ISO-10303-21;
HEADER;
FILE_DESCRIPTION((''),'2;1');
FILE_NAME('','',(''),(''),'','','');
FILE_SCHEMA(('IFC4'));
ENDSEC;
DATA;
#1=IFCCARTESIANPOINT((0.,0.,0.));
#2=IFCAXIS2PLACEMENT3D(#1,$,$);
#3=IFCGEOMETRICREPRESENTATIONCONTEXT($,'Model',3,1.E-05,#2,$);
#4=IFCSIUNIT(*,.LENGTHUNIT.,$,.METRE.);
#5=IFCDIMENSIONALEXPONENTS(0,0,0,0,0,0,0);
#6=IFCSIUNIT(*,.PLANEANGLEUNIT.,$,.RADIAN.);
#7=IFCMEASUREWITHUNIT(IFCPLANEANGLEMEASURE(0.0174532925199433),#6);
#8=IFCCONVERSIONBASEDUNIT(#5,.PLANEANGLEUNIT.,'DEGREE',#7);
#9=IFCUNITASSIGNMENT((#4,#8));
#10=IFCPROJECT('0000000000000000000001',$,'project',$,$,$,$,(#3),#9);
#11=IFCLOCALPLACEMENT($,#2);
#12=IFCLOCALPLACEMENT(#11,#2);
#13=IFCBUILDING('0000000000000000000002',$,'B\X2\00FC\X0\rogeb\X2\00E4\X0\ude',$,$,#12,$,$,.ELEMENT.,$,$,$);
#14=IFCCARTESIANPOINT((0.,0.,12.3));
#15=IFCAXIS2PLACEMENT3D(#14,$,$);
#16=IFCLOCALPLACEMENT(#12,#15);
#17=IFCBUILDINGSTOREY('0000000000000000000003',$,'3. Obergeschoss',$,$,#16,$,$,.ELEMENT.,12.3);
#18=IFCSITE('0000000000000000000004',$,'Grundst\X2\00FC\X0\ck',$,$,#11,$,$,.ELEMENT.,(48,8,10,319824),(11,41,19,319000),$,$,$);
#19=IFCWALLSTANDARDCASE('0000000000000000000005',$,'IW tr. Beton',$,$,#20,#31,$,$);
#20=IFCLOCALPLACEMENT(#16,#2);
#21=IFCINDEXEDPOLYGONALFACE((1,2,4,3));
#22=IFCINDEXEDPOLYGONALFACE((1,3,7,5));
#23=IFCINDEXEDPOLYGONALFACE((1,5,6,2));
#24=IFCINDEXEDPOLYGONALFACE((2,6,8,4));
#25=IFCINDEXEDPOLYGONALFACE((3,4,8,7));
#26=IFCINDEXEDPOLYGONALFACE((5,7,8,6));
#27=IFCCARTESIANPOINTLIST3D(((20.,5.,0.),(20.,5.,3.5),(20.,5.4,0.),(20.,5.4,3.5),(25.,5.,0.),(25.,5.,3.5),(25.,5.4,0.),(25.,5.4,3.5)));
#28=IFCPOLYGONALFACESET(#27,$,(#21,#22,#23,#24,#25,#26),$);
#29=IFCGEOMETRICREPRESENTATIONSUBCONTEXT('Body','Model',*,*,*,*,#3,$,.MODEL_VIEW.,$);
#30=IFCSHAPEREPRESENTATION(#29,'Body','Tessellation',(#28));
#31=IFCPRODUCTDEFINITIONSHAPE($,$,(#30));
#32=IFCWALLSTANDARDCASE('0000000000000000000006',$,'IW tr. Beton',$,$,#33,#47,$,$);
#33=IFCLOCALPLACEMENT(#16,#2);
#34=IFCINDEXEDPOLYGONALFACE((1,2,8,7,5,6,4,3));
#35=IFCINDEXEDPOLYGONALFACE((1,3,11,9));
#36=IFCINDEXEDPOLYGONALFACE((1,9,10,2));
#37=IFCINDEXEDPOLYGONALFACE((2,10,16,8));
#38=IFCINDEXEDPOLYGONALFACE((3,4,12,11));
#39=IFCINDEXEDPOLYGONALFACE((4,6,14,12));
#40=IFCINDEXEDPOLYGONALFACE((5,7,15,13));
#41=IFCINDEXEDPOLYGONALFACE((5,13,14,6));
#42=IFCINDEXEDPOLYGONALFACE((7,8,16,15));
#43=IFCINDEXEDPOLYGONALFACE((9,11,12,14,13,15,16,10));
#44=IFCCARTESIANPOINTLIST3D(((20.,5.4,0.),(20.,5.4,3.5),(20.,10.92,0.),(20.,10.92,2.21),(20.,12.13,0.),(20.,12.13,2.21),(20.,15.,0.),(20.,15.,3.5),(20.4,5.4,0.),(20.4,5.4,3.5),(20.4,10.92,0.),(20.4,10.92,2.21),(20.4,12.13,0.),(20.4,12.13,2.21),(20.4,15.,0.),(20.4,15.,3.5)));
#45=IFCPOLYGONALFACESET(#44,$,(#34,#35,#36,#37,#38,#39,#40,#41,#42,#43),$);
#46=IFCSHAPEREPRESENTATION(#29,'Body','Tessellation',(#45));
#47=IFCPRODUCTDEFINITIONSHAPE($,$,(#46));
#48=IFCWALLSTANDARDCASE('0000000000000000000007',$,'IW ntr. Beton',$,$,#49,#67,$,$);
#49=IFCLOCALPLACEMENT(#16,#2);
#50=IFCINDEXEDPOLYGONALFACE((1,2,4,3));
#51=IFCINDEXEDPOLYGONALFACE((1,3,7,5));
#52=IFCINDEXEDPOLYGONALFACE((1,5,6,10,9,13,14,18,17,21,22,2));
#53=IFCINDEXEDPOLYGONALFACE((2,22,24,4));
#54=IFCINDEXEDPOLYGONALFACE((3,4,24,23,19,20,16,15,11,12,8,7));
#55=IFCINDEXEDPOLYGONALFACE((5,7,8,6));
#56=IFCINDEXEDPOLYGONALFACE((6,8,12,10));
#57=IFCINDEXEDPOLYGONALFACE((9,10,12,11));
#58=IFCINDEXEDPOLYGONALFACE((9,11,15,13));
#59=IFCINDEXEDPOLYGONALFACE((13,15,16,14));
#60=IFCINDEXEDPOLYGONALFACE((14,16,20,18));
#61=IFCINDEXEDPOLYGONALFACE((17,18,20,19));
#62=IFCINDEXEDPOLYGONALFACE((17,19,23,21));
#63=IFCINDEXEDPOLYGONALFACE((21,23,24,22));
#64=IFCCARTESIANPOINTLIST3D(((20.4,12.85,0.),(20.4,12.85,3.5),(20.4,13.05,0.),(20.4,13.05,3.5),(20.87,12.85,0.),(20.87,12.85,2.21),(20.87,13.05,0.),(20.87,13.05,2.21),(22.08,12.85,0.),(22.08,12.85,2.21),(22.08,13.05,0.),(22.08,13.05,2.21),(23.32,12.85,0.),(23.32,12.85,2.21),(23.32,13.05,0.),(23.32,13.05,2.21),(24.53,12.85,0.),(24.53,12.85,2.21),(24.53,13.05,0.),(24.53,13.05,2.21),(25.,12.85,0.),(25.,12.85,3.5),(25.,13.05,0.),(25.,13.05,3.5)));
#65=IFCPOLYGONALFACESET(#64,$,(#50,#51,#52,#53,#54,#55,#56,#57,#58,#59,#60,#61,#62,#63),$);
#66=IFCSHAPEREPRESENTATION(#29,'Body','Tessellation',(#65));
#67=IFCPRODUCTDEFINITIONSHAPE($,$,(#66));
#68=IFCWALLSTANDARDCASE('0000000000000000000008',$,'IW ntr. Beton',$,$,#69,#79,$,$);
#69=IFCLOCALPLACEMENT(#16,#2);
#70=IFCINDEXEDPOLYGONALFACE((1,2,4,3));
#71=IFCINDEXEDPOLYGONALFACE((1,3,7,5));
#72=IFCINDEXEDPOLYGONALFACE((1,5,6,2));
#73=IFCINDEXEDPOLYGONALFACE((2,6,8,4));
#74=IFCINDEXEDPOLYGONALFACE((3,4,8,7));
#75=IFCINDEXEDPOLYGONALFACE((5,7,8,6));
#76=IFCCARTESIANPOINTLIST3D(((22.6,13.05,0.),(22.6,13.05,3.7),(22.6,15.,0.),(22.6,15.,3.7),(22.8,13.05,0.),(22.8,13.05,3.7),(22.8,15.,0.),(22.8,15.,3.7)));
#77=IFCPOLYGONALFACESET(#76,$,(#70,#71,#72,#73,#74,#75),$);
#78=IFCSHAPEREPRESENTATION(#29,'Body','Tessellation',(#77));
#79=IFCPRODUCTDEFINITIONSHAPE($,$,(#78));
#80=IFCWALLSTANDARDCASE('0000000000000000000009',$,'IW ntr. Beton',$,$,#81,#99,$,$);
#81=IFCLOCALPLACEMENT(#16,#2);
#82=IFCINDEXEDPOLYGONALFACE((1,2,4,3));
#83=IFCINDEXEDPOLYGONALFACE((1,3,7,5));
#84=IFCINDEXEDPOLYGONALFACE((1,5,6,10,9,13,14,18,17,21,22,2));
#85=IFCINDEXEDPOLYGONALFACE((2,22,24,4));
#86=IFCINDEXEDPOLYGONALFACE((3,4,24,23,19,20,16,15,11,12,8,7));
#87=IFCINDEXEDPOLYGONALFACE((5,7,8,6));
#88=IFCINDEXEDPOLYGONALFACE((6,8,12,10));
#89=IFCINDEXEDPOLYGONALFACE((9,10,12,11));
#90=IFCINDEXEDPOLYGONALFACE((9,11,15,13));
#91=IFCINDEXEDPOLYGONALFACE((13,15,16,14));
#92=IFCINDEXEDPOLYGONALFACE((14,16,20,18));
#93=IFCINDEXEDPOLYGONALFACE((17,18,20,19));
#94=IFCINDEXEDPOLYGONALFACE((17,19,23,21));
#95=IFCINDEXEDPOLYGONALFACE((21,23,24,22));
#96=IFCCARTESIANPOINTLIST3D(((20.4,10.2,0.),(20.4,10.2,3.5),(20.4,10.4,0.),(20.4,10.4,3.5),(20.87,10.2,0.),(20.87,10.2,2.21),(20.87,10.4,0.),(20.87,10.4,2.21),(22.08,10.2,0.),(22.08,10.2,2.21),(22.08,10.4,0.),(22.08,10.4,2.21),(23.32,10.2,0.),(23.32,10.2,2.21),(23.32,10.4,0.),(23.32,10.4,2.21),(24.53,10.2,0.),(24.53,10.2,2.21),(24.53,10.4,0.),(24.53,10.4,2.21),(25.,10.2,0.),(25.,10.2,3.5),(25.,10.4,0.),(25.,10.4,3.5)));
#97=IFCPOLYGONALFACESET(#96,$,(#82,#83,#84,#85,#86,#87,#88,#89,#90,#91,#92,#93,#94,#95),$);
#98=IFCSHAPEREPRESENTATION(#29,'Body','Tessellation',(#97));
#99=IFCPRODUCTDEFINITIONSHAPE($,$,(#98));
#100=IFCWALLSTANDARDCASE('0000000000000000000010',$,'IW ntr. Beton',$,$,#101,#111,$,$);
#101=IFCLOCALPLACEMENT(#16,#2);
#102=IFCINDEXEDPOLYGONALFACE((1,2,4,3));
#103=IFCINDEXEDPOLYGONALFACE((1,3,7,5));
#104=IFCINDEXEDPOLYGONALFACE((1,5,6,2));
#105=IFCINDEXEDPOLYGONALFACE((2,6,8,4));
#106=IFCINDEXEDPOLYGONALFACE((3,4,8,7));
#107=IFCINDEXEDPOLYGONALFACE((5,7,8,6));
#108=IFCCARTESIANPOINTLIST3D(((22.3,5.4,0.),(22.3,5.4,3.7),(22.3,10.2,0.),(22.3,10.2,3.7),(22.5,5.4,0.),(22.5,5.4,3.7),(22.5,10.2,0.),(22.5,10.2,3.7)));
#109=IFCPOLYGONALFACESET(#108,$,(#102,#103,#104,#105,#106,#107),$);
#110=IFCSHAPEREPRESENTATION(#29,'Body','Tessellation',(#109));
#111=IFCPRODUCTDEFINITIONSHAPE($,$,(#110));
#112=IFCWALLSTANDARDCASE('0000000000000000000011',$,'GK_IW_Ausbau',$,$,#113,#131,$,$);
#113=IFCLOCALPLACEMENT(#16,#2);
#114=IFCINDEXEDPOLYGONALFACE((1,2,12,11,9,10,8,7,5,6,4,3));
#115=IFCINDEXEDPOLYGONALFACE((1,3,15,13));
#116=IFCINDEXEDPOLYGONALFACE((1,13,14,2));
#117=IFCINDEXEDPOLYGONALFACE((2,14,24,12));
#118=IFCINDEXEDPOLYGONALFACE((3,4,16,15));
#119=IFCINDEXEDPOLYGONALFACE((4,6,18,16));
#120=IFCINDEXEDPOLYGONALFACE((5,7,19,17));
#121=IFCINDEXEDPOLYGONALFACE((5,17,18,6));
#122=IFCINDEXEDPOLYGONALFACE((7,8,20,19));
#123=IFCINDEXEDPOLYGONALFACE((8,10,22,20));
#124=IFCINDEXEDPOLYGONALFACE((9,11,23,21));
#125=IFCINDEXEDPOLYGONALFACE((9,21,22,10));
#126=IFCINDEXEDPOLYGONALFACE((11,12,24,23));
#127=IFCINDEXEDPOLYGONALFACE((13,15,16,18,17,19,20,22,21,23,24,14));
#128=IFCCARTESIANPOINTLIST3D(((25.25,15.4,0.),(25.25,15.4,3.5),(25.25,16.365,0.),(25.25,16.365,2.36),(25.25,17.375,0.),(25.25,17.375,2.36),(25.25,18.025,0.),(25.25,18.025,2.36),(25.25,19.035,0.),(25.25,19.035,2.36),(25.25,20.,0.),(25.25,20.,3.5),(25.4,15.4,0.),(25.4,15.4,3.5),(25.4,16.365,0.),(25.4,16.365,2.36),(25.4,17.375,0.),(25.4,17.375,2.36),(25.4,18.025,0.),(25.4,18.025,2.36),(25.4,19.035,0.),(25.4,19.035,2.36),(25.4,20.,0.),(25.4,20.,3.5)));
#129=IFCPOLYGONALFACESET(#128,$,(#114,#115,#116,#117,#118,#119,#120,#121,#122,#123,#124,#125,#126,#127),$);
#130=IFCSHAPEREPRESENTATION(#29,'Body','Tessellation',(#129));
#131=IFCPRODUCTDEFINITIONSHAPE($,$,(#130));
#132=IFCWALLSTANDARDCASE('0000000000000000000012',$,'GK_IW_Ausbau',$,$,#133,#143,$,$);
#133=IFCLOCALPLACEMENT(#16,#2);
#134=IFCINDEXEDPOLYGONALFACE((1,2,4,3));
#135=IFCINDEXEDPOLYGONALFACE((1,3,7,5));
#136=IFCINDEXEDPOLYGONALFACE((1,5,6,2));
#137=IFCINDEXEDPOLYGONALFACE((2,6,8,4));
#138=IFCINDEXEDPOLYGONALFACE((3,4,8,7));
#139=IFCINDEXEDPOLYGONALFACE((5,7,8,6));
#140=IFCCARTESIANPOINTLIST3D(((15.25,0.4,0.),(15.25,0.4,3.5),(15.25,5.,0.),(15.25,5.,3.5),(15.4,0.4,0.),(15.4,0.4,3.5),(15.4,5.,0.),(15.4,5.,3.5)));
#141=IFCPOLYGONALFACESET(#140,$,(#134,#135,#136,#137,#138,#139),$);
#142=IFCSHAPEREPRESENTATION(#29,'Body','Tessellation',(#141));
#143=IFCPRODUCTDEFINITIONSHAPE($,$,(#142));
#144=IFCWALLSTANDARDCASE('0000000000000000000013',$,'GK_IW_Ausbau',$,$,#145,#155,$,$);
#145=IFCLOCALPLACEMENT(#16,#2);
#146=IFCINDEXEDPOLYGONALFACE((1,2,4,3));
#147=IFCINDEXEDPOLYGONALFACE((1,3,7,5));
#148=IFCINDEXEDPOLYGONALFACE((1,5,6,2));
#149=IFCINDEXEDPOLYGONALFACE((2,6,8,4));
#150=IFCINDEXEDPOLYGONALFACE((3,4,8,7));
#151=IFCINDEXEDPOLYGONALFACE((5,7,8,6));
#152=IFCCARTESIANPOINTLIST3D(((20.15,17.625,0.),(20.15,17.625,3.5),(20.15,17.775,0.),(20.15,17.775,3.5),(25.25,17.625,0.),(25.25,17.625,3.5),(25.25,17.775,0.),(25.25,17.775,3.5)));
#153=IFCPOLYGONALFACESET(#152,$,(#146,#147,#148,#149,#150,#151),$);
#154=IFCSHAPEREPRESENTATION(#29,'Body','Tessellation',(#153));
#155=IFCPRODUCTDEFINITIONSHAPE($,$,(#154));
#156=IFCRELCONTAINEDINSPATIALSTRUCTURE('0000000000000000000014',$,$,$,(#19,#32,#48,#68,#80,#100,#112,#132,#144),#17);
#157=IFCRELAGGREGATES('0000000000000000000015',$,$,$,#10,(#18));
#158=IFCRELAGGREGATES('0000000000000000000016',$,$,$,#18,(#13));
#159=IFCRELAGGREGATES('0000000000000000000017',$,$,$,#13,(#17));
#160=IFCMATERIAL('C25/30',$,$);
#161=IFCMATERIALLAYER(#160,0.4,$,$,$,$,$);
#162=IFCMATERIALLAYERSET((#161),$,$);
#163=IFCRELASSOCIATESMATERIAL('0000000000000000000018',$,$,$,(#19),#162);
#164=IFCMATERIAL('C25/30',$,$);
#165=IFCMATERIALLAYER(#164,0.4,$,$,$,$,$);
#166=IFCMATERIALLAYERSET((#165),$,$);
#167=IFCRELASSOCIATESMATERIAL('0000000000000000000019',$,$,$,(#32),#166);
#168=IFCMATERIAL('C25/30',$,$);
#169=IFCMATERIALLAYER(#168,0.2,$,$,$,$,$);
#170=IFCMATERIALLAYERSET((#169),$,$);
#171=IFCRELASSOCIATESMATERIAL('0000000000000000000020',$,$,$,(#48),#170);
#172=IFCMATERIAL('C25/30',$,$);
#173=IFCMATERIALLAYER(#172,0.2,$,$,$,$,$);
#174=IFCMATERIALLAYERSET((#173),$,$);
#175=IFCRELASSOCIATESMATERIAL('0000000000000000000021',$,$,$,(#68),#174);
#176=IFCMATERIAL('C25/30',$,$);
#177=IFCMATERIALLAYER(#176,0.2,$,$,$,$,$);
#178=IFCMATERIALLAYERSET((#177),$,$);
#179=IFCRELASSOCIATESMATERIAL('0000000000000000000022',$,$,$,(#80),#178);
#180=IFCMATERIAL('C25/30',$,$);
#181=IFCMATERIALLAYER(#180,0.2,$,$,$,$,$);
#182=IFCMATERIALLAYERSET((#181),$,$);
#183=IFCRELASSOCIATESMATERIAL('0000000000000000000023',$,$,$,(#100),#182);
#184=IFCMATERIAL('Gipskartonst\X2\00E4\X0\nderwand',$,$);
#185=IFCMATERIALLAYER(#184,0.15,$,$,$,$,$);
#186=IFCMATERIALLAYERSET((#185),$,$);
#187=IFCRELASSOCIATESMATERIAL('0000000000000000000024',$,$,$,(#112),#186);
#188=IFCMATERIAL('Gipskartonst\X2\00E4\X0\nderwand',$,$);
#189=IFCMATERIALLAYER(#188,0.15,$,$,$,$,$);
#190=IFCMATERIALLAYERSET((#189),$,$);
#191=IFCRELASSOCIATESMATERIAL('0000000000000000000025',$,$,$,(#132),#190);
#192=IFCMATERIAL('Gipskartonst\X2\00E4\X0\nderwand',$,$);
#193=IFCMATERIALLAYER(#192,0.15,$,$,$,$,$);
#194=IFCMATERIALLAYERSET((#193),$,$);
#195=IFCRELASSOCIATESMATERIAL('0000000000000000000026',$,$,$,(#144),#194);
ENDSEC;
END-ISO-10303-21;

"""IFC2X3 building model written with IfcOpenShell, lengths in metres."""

from ifc_helpers import new_model, entity, si_unit, converted_unit, frame, frame_2d, origin, origin_with_axes, place, context, subcontext, project, spatial, polyline, rectangle, outline, extrude, material, layer, layer_set, layer_usage, element, save


model = new_model("IFC2X3")

# Units and contexts
model_context = context("Model", 3, precision=1e-05, world=origin())
body_context = subcontext(model_context, "Body", "Model", "MODEL_VIEW")
ifc_project = project(units=[si_unit("LENGTHUNIT", "METRE"), converted_unit("PLANEANGLEUNIT", "DEGREE", entity("IfcPlaneAngleMeasure", 0.0174532925199433), si_unit("PLANEANGLEUNIT", "RADIAN"), dimensions=[0, 0, 0, 0, 0, 0, 0])], contexts=[model_context])

# Site, building, storey
site_placement = place(None, origin())
site = spatial("IfcSite", under=ifc_project, at=site_placement, Name="Grundstück", CompositionType="ELEMENT", RefLatitude=(48, 8, 10, 319824), RefLongitude=(11, 41, 19, 319000))
building_placement = place(site_placement, origin())
building = spatial("IfcBuilding", under=site, at=building_placement, Name="Bürogebäude", CompositionType="ELEMENT")
storey_placement = place(building_placement, frame((0.0, 0.0, 12.3)))
storey = spatial("IfcBuildingStorey", under=building, at=storey_placement, Name="3. Obergeschoss", CompositionType="ELEMENT", Elevation=12.3)

# Wall
ifc_material_1 = material(Name="C25/30")
ifc_layer_1 = layer(ifc_material_1, 0.4)
ifc_layer_set_1 = layer_set([ifc_layer_1])
ifc_layer_usage_1 = layer_usage(ifc_layer_set_1, "AXIS2", "POSITIVE", -0.2)
wall_1_placement = place(storey_placement, frame((25.0, 5.4, 0.0), z_axis=(0.0, 0.0, 1.0), x_axis=(-1.0, 0.0, 0.0)))
element("IfcWallStandardCase", 1, at=wall_1_placement, inside=storey, material=ifc_layer_usage_1, Name="IW tr. Beton", context=body_context, shape_type="SweptSolid", body=[
    extrude(rectangle(XDim=5.0, YDim=0.4, at=frame_2d((2.5, 0.2), x_axis=(1.0, 0.0))), origin_with_axes(), (0.0, 0.0, 1.0), 3.5),
])

# Wall, opening
ifc_material_2 = material(Name="C25/30")
ifc_layer_2 = layer(ifc_material_2, 0.4)
ifc_layer_set_2 = layer_set([ifc_layer_2])
ifc_layer_usage_2 = layer_usage(ifc_layer_set_2, "AXIS2", "POSITIVE", -0.2)
wall_2_placement = place(storey_placement, frame((20.4, 5.4, 0.0), z_axis=(0.0, 0.0, 1.0), x_axis=(0.0, 1.0, 0.0)))
wall_2 = element("IfcWallStandardCase", 2, at=wall_2_placement, inside=storey, material=ifc_layer_usage_2, Name="IW tr. Beton", context=body_context, shape_type="SweptSolid", body=[
    extrude(rectangle(XDim=9.6, YDim=0.4, at=frame_2d((4.8, 0.2), x_axis=(1.0, 0.0))), origin_with_axes(), (0.0, 0.0, 1.0), 3.5),
])
opening_1_placement = place(wall_2_placement, frame((5.52, 0.0, 0.0), z_axis=(0.0, 1.0, 0.0), x_axis=(0.0, 0.0, 1.0)))
element("IfcOpeningElement", 3, at=opening_1_placement, cuts=wall_2, ObjectType="Opening", context=body_context, shape_type="SweptSolid", body=[
    extrude(outline(polyline([(0.0, 1.21), (2.21, 1.21), (2.21, 0.0), (0.0, 0.0), (0.0, 1.21)])), origin_with_axes(), (0.0, 0.0, 1.0), 0.4),
])

# Wall, openings
ifc_material_3 = material(Name="C25/30")
ifc_layer_3 = layer(ifc_material_3, 0.2)
ifc_layer_set_3 = layer_set([ifc_layer_3])
ifc_layer_usage_3 = layer_usage(ifc_layer_set_3, "AXIS2", "POSITIVE", -0.2)
wall_3_placement = place(storey_placement, frame((25.0, 13.05, 0.0), z_axis=(0.0, 0.0, 1.0), x_axis=(-1.0, 0.0, 0.0)))
wall_3 = element("IfcWallStandardCase", 4, at=wall_3_placement, inside=storey, material=ifc_layer_usage_3, Name="IW ntr. Beton", context=body_context, shape_type="SweptSolid", body=[
    extrude(rectangle(XDim=4.6, YDim=0.2, at=frame_2d((2.3, 0.1), x_axis=(1.0, 0.0))), origin_with_axes(), (0.0, 0.0, 1.0), 3.5),
])
opening_2_placement = place(wall_3_placement, frame((1.68, 0.2, 0.0), z_axis=(0.0, -1.0, 0.0), x_axis=(0.0, 0.0, 1.0)))
element("IfcOpeningElement", 5, at=opening_2_placement, cuts=wall_3, ObjectType="Opening", context=body_context, shape_type="SweptSolid", body=[
    extrude(outline(polyline([(0.0, 1.21), (2.21, 1.21), (2.21, 0.0), (0.0, 0.0), (0.0, 1.21)])), origin_with_axes(), (0.0, 0.0, 1.0), 0.2),
])
opening_3_placement = place(wall_3_placement, frame((4.13, 0.2, 0.0), z_axis=(0.0, -1.0, 0.0), x_axis=(0.0, 0.0, 1.0)))
element("IfcOpeningElement", 6, at=opening_3_placement, cuts=wall_3, ObjectType="Opening", context=body_context, shape_type="SweptSolid", body=[
    extrude(outline(polyline([(0.0, 1.21), (2.21, 1.21), (2.21, 0.0), (0.0, 0.0), (0.0, 1.21)])), origin_with_axes(), (0.0, 0.0, 1.0), 0.2),
])

# Wall
ifc_material_4 = material(Name="C25/30")
ifc_layer_4 = layer(ifc_material_4, 0.2)
ifc_layer_set_4 = layer_set([ifc_layer_4])
ifc_layer_usage_4 = layer_usage(ifc_layer_set_4, "AXIS2", "POSITIVE", -0.2)
wall_4_placement = place(storey_placement, frame((22.6, 15.0, 0.0), z_axis=(0.0, 0.0, 1.0), x_axis=(0.0, -1.0, 0.0)))
element("IfcWallStandardCase", 7, at=wall_4_placement, inside=storey, material=ifc_layer_usage_4, Name="IW ntr. Beton", context=body_context, shape_type="SweptSolid", body=[
    extrude(rectangle(XDim=1.95, YDim=0.2, at=frame_2d((0.975, 0.1), x_axis=(1.0, 0.0))), origin_with_axes(), (0.0, 0.0, 1.0), 3.7),
])

# Wall, openings
ifc_material_5 = material(Name="C25/30")
ifc_layer_5 = layer(ifc_material_5, 0.2)
ifc_layer_set_5 = layer_set([ifc_layer_5])
ifc_layer_usage_5 = layer_usage(ifc_layer_set_5, "AXIS2", "POSITIVE", -0.2)
wall_5_placement = place(storey_placement, frame((25.0, 10.4, 0.0), z_axis=(0.0, 0.0, 1.0), x_axis=(-1.0, 0.0, 0.0)))
wall_5 = element("IfcWallStandardCase", 8, at=wall_5_placement, inside=storey, material=ifc_layer_usage_5, Name="IW ntr. Beton", context=body_context, shape_type="SweptSolid", body=[
    extrude(rectangle(XDim=4.6, YDim=0.2, at=frame_2d((2.3, 0.1), x_axis=(1.0, 0.0))), origin_with_axes(), (0.0, 0.0, 1.0), 3.5),
])
opening_4_placement = place(wall_5_placement, frame((1.68, 0.2, 0.0), z_axis=(0.0, -1.0, 0.0), x_axis=(0.0, 0.0, 1.0)))
element("IfcOpeningElement", 9, at=opening_4_placement, cuts=wall_5, ObjectType="Opening", context=body_context, shape_type="SweptSolid", body=[
    extrude(outline(polyline([(0.0, 1.21), (2.21, 1.21), (2.21, 0.0), (0.0, 0.0), (0.0, 1.21)])), origin_with_axes(), (0.0, 0.0, 1.0), 0.2),
])
opening_5_placement = place(wall_5_placement, frame((4.13, 0.2, 0.0), z_axis=(0.0, -1.0, 0.0), x_axis=(0.0, 0.0, 1.0)))
element("IfcOpeningElement", 10, at=opening_5_placement, cuts=wall_5, ObjectType="Opening", context=body_context, shape_type="SweptSolid", body=[
    extrude(outline(polyline([(0.0, 1.21), (2.21, 1.21), (2.21, 0.0), (0.0, 0.0), (0.0, 1.21)])), origin_with_axes(), (0.0, 0.0, 1.0), 0.2),
])

# Wall
ifc_material_6 = material(Name="C25/30")
ifc_layer_6 = layer(ifc_material_6, 0.2)
ifc_layer_set_6 = layer_set([ifc_layer_6])
ifc_layer_usage_6 = layer_usage(ifc_layer_set_6, "AXIS2", "POSITIVE", -0.2)
wall_6_placement = place(storey_placement, frame((22.3, 10.2, 0.0), z_axis=(0.0, 0.0, 1.0), x_axis=(0.0, -1.0, 0.0)))
element("IfcWallStandardCase", 11, at=wall_6_placement, inside=storey, material=ifc_layer_usage_6, Name="IW ntr. Beton", context=body_context, shape_type="SweptSolid", body=[
    extrude(rectangle(XDim=4.8, YDim=0.2, at=frame_2d((2.4, 0.1), x_axis=(1.0, 0.0))), origin_with_axes(), (0.0, 0.0, 1.0), 3.7),
])

# Wall, openings
ifc_material_7 = material(Name="Gipskartonständerwand")
ifc_layer_7 = layer(ifc_material_7, 0.15)
ifc_layer_set_7 = layer_set([ifc_layer_7])
ifc_layer_usage_7 = layer_usage(ifc_layer_set_7, "AXIS2", "POSITIVE", -0.15)
wall_7_placement = place(storey_placement, frame((25.25, 20.0, 0.0), z_axis=(0.0, 0.0, 1.0), x_axis=(0.0, -1.0, 0.0)))
wall_7 = element("IfcWallStandardCase", 12, at=wall_7_placement, inside=storey, material=ifc_layer_usage_7, Name="GK_IW_Ausbau", context=body_context, shape_type="SweptSolid", body=[
    extrude(rectangle(XDim=4.6, YDim=0.15, at=frame_2d((2.3, 0.075), x_axis=(1.0, 0.0))), origin_with_axes(), (0.0, 0.0, 1.0), 3.5),
])
opening_6_placement = place(wall_7_placement, frame((1.975, 0.15, 0.0), z_axis=(0.0, -1.0, 0.0), x_axis=(0.0, 0.0, 1.0)))
element("IfcOpeningElement", 13, at=opening_6_placement, cuts=wall_7, ObjectType="Opening", context=body_context, shape_type="SweptSolid", body=[
    extrude(outline(polyline([(0.0, 1.01), (2.36, 1.01), (2.36, 0.0), (0.0, 0.0), (0.0, 1.01)])), origin_with_axes(), (0.0, 0.0, 1.0), 0.15),
])
opening_7_placement = place(wall_7_placement, frame((3.635, 0.15, 0.0), z_axis=(0.0, -1.0, 0.0), x_axis=(0.0, 0.0, 1.0)))
element("IfcOpeningElement", 14, at=opening_7_placement, cuts=wall_7, ObjectType="Opening", context=body_context, shape_type="SweptSolid", body=[
    extrude(outline(polyline([(0.0, 1.01), (2.36, 1.01), (2.36, 0.0), (0.0, 0.0), (0.0, 1.01)])), origin_with_axes(), (0.0, 0.0, 1.0), 0.15),
])

# Walls
ifc_material_8 = material(Name="Gipskartonständerwand")
ifc_layer_8 = layer(ifc_material_8, 0.15)
ifc_layer_set_8 = layer_set([ifc_layer_8])
ifc_layer_usage_8 = layer_usage(ifc_layer_set_8, "AXIS2", "POSITIVE", -0.15)
wall_8_placement = place(storey_placement, frame((15.25, 5.0, 0.0), z_axis=(0.0, 0.0, 1.0), x_axis=(0.0, -1.0, 0.0)))
element("IfcWallStandardCase", 15, at=wall_8_placement, inside=storey, material=ifc_layer_usage_8, Name="GK_IW_Ausbau", context=body_context, shape_type="SweptSolid", body=[
    extrude(rectangle(XDim=4.6, YDim=0.15, at=frame_2d((2.3, 0.075), x_axis=(1.0, 0.0))), origin_with_axes(), (0.0, 0.0, 1.0), 3.5),
])
ifc_material_9 = material(Name="Gipskartonständerwand")
ifc_layer_9 = layer(ifc_material_9, 0.15)
ifc_layer_set_9 = layer_set([ifc_layer_9])
ifc_layer_usage_9 = layer_usage(ifc_layer_set_9, "AXIS2", "POSITIVE", -0.075)
wall_9_placement = place(storey_placement, frame((20.15, 17.625, 0.0)))
element("IfcWallStandardCase", 16, at=wall_9_placement, inside=storey, material=ifc_layer_usage_9, Name="GK_IW_Ausbau", context=body_context, shape_type="SweptSolid", body=[
    extrude(rectangle(XDim=5.1, YDim=0.15, at=frame_2d((2.55, 0.075), x_axis=(1.0, 0.0))), origin_with_axes(), (0.0, 0.0, 1.0), 3.5),
])

save(model, "model.ifc")
